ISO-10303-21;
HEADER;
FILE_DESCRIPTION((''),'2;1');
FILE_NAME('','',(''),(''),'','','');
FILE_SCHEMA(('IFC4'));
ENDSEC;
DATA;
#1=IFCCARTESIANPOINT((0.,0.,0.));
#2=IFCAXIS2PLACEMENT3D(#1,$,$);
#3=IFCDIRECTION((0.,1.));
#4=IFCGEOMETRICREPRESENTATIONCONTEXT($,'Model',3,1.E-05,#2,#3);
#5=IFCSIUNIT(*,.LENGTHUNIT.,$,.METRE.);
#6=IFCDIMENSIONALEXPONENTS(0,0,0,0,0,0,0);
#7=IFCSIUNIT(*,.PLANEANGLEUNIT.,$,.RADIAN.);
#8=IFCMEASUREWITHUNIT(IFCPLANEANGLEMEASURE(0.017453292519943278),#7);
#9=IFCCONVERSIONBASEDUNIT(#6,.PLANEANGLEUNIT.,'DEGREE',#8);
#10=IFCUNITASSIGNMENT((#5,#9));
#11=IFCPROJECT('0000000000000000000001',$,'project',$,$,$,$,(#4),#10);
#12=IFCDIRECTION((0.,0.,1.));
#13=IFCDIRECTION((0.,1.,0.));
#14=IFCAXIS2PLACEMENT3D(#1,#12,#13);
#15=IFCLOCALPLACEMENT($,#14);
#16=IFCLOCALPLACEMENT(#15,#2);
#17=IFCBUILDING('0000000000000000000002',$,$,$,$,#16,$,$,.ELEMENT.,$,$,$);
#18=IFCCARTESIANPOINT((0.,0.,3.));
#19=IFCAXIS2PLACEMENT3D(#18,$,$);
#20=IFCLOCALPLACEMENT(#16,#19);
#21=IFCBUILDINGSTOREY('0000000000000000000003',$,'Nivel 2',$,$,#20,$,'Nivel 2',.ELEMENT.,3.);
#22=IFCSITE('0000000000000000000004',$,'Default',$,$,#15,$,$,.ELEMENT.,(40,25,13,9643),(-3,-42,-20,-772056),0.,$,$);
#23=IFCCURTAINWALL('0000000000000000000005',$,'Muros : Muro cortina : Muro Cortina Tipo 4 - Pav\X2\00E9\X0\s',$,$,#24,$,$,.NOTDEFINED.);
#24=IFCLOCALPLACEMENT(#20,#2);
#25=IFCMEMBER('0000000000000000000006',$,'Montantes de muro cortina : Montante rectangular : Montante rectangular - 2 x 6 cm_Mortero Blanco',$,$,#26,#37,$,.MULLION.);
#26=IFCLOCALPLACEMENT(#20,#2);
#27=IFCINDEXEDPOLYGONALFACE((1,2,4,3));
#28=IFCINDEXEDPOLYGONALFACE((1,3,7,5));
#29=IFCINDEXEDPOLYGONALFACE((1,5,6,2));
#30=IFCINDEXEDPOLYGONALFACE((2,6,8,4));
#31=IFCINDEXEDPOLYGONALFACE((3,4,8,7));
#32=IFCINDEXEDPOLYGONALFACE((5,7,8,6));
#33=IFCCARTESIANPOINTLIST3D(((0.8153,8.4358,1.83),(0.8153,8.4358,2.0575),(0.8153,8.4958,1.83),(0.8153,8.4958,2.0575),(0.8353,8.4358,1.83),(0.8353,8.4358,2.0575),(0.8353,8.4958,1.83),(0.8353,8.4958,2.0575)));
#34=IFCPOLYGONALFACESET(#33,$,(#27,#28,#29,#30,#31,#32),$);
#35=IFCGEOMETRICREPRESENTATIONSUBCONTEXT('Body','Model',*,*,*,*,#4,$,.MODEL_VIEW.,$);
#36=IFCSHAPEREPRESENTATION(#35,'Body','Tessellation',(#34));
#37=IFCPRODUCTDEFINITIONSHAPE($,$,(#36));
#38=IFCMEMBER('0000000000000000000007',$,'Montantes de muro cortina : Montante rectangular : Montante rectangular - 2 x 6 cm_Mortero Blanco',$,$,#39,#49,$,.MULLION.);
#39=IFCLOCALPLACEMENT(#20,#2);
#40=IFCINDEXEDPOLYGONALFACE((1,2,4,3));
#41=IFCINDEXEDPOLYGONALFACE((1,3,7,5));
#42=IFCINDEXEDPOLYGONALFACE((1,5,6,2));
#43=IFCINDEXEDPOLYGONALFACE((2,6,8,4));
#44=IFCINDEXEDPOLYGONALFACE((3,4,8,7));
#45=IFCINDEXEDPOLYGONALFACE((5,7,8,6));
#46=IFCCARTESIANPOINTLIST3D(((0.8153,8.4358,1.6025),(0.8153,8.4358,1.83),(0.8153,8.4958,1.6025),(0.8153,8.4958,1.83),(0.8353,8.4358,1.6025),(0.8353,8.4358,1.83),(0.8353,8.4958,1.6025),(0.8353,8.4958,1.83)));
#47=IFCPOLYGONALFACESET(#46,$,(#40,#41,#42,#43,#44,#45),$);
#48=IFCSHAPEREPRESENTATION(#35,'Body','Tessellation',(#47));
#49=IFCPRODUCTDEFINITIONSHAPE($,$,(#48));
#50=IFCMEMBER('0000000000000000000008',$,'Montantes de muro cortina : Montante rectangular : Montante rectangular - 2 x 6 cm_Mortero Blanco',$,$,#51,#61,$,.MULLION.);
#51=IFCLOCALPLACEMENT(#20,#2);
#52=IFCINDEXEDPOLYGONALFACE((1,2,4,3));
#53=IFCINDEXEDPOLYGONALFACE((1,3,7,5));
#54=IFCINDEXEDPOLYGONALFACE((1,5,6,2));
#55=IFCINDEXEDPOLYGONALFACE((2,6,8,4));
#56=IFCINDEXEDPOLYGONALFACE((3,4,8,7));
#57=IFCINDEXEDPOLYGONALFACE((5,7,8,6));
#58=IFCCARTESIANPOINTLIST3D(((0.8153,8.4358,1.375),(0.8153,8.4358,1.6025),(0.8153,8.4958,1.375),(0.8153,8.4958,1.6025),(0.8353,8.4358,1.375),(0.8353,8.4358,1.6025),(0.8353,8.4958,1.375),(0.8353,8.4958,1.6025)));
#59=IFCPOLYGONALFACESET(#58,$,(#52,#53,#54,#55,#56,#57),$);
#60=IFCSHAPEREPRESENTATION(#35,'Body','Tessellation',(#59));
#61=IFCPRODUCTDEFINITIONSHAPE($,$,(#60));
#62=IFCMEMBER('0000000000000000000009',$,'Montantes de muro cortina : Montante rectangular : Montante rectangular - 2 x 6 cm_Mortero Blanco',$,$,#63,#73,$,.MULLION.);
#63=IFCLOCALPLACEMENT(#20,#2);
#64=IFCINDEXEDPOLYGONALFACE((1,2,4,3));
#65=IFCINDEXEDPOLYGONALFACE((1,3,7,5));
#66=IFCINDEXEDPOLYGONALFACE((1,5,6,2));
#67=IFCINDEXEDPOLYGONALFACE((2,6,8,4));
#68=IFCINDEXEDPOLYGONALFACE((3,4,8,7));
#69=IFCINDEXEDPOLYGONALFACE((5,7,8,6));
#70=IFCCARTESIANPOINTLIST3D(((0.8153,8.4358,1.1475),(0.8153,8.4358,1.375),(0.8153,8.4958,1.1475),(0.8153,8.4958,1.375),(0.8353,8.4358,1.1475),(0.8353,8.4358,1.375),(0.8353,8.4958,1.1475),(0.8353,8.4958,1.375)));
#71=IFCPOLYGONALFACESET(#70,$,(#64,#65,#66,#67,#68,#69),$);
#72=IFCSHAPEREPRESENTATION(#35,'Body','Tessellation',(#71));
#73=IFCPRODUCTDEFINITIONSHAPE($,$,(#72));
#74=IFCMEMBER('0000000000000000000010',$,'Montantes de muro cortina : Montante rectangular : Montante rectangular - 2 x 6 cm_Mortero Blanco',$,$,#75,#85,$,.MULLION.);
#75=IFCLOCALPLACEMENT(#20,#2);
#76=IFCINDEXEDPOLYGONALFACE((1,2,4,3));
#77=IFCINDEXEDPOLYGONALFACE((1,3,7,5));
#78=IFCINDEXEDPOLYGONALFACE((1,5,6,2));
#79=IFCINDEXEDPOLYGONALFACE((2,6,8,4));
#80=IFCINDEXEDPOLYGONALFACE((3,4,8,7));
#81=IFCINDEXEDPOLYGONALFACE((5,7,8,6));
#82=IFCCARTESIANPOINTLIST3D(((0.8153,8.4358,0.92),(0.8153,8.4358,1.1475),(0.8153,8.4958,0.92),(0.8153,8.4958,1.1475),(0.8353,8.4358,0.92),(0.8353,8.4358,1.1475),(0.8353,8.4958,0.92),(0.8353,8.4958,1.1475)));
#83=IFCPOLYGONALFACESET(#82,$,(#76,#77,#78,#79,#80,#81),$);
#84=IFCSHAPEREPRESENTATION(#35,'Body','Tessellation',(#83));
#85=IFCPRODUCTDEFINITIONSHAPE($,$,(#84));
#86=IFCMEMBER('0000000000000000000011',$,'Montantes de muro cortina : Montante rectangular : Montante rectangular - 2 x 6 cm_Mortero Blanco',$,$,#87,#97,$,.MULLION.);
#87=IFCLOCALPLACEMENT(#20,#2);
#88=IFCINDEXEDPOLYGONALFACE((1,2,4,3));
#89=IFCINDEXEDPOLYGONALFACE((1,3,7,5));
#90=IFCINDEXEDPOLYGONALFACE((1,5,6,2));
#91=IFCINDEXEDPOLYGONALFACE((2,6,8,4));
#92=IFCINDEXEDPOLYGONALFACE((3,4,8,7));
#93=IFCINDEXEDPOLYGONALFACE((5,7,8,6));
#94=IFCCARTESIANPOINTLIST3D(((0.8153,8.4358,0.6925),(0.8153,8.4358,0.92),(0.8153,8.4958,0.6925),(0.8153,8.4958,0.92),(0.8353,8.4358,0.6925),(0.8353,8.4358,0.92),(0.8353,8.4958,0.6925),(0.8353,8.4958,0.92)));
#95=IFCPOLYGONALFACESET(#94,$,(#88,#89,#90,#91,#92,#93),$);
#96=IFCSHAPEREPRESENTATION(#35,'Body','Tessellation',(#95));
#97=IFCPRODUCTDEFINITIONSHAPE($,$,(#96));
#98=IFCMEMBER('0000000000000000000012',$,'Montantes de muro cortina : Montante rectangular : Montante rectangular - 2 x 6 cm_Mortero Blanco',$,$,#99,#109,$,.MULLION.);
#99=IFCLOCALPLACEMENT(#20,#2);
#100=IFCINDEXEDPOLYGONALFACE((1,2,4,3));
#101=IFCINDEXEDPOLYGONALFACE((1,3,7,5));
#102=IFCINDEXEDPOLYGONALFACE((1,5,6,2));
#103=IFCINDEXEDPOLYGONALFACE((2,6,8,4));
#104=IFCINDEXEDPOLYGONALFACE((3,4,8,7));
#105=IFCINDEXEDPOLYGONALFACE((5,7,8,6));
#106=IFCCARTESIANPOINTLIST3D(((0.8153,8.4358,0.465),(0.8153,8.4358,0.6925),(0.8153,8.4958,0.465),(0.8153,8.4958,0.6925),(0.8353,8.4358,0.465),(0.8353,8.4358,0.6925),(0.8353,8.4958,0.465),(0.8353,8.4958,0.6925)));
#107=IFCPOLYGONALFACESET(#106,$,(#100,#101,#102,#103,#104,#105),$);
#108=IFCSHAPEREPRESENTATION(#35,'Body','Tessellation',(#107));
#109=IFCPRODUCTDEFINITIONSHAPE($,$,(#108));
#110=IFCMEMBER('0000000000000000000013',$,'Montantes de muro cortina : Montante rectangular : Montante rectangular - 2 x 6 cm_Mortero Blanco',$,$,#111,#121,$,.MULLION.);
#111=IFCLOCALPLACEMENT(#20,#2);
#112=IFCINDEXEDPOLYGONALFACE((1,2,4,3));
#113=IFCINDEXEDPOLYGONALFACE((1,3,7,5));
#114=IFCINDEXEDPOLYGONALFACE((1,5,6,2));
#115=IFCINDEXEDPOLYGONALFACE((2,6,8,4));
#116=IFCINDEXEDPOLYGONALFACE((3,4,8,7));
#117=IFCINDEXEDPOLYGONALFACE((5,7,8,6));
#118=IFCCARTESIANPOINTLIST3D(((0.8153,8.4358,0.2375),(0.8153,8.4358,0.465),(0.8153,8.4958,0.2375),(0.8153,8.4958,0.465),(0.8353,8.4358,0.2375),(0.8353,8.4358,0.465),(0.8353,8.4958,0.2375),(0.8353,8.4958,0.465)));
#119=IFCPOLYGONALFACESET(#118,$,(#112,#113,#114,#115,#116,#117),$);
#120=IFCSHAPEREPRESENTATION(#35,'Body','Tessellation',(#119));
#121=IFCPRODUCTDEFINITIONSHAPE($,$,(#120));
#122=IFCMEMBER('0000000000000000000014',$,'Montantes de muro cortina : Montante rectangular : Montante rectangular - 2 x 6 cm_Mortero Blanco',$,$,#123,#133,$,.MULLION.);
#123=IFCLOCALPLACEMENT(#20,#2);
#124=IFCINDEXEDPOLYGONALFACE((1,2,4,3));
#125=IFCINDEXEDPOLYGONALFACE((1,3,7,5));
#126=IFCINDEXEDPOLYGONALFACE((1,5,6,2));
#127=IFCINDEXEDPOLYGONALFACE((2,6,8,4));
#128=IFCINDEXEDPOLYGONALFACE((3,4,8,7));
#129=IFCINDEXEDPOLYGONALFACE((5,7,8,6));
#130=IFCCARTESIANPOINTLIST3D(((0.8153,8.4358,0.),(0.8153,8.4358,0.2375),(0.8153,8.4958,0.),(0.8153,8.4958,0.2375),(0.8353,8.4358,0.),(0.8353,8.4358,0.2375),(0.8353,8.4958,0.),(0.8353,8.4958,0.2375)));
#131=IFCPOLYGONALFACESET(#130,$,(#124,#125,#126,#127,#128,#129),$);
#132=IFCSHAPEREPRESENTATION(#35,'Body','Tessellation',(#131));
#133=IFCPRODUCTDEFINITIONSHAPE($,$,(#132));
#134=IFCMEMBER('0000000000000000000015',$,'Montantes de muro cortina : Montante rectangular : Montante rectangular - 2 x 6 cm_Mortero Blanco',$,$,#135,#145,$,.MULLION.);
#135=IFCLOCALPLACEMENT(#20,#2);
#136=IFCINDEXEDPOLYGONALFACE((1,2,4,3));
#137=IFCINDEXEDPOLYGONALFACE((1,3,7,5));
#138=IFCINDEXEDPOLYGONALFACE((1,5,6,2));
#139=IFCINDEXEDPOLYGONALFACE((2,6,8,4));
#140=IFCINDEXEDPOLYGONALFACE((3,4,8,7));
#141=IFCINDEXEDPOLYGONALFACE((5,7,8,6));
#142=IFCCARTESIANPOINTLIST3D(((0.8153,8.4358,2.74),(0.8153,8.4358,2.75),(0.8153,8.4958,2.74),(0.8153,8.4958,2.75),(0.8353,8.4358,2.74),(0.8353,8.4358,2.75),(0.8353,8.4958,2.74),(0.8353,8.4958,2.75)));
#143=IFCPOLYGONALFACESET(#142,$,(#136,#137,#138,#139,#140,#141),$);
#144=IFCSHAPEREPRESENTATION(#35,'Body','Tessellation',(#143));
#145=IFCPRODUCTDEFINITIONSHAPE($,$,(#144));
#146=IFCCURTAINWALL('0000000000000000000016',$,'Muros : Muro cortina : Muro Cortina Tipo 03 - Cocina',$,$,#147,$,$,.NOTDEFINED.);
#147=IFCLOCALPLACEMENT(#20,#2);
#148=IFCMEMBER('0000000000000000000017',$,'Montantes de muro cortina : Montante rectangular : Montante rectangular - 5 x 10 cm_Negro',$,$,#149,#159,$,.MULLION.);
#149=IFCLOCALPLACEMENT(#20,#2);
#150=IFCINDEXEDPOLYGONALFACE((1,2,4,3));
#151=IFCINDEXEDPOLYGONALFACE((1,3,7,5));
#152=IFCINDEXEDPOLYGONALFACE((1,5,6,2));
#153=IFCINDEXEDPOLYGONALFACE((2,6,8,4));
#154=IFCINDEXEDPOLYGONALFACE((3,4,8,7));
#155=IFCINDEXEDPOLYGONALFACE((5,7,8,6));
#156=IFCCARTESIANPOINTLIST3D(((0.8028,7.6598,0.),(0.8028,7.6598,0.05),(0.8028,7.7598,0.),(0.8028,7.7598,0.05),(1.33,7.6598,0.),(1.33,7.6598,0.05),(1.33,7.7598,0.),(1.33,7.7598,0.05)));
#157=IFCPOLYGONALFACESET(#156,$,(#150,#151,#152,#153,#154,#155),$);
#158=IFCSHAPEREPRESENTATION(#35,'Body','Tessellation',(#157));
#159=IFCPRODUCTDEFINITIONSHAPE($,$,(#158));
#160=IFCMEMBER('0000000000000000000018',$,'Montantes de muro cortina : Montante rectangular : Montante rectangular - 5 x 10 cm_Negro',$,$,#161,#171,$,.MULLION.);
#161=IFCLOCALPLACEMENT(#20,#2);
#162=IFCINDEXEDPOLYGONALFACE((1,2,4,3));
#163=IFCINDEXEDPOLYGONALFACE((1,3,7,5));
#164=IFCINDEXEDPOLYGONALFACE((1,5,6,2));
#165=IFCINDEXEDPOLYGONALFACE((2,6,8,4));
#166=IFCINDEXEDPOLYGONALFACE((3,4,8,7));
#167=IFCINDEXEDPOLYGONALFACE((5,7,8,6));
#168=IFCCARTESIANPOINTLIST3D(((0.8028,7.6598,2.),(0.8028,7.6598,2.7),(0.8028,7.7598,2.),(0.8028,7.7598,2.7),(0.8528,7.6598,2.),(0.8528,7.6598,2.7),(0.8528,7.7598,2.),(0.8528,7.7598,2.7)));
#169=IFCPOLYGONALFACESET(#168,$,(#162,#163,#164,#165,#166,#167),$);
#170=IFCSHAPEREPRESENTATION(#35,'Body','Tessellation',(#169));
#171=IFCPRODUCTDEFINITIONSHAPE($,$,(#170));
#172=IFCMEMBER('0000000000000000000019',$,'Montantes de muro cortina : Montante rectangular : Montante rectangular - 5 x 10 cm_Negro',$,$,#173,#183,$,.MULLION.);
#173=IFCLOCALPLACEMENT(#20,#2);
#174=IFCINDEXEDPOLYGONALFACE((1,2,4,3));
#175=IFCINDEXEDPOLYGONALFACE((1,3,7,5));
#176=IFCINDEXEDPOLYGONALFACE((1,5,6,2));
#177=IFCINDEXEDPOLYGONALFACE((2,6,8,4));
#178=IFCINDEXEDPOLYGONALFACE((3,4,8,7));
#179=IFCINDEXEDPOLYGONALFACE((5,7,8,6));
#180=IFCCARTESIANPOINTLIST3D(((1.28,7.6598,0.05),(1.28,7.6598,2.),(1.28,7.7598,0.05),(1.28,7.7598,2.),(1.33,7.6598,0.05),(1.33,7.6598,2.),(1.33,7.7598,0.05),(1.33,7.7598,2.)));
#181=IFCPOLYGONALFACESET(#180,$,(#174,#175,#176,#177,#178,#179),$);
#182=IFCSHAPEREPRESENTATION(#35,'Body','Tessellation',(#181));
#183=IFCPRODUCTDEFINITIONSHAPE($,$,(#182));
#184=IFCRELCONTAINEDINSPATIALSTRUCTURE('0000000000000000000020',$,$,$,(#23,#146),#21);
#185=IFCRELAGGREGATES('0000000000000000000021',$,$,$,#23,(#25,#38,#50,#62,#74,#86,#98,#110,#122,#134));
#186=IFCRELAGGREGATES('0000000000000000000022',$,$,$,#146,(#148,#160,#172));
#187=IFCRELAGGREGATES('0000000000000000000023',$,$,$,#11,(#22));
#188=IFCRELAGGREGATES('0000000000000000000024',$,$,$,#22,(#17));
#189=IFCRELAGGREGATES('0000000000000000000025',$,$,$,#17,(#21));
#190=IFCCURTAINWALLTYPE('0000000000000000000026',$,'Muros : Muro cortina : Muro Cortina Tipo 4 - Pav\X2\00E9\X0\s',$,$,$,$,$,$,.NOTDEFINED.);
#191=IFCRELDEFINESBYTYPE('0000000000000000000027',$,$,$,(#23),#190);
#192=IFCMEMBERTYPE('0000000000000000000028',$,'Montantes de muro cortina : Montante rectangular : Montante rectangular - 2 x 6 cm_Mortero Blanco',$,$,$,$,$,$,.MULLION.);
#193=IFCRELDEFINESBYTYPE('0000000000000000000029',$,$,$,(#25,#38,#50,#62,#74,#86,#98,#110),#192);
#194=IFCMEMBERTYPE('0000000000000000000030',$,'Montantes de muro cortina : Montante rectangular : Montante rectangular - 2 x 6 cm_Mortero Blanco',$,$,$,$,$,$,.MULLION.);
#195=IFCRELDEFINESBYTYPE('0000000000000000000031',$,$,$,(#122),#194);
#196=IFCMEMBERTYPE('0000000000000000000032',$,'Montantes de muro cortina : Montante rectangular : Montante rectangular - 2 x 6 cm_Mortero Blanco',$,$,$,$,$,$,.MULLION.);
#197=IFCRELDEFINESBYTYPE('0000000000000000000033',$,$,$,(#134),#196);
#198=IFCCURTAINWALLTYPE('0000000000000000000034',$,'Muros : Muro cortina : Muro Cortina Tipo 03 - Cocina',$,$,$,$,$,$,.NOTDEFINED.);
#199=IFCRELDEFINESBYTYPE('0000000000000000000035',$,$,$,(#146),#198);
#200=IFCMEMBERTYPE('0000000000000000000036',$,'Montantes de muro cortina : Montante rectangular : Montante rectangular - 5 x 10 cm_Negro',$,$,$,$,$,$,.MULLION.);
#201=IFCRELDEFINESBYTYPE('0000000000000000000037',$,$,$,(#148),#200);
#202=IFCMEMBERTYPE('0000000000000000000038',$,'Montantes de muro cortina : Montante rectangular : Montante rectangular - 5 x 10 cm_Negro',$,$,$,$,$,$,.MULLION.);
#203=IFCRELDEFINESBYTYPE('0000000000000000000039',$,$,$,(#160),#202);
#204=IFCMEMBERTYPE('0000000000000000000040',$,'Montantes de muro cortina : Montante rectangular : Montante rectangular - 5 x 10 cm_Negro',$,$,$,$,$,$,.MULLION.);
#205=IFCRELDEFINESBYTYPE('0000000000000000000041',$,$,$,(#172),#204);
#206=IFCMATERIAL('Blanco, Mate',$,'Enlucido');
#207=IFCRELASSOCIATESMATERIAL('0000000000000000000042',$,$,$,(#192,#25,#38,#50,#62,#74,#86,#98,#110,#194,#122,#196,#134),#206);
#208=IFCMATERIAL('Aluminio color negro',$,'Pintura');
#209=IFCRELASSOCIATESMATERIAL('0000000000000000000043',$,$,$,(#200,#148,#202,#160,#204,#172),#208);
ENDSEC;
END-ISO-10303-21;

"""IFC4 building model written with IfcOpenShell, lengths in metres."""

from ifc_helpers import new_model, entity, si_unit, converted_unit, direction, frame, origin, place, context, subcontext, project, spatial, indexed_curve, outline, extrude, source, transform, mapped, material, type_object, type_shapes, element, aggregate, save


model = new_model("IFC4")

# Units and contexts
model_context = context("Model", 3, precision=1e-05, world=origin(), true_north=direction((0.0, 1.0)))
body_context = subcontext(model_context, "Body", "Model", "MODEL_VIEW")
ifc_project = project(units=[si_unit("LENGTHUNIT", "METRE"), converted_unit("PLANEANGLEUNIT", "DEGREE", entity("IfcPlaneAngleMeasure", 0.017453292519943278), si_unit("PLANEANGLEUNIT", "RADIAN"), dimensions=[0, 0, 0, 0, 0, 0, 0])], contexts=[model_context])

# Site, building, storey
site_placement = place(None, frame((0.0, 0.0, 0.0), z_axis=(0.0, 0.0, 1.0), x_axis=(0.0, 1.0, 0.0)))
site = spatial("IfcSite", under=ifc_project, at=site_placement, Name="Default", CompositionType="ELEMENT", RefLatitude=(40, 25, 13, 9643), RefLongitude=(-3, -42, -20, -772056), RefElevation=0.0)
building_placement = place(site_placement, origin())
building = spatial("IfcBuilding", under=site, at=building_placement, CompositionType="ELEMENT")
storey_placement = place(building_placement, frame((0.0, 0.0, 3.0)))
storey = spatial("IfcBuildingStorey", under=building, at=storey_placement, Name="Nivel 2", LongName="Nivel 2", CompositionType="ELEMENT", Elevation=3.0)

# Curtain wall, members
curtain_wall_type_1 = type_object("IfcCurtainWallType", Name="Muros : Muro cortina : Muro Cortina Tipo 4 - Pavés", PredefinedType="NOTDEFINED")
curtain_wall_1_placement = place(storey_placement, frame((0.0, 0.0, -3.0)))
curtain_wall_1 = element("IfcCurtainWall", 1, at=curtain_wall_1_placement, inside=storey, type_object=curtain_wall_type_1, Name="Muros : Muro cortina : Muro Cortina Tipo 4 - Pavés", PredefinedType="NOTDEFINED")
ifc_material_1 = material(Name="Blanco, Mate", Category="Enlucido")
member_type_1 = type_object("IfcMemberType", Name="Montantes de muro cortina : Montante rectangular : Montante rectangular - 2 x 6 cm_Mortero Blanco", PredefinedType="MULLION", material=ifc_material_1)
shared_shape_1 = source(origin(), body_context, "Body", "SweptSolid", [
    extrude(outline(indexed_curve([(-0.01, -0.03), (0.01, -0.03), (0.01, 0.03), (-0.01, 0.03), (-0.01, -0.03)], self_intersect=False)), frame((-0.01, 0.0, -0.2275), z_axis=(0.0, 0.0, 1.0), x_axis=(-1.0, 0.0, 0.0)), (0.0, 0.0, 1.0), 0.2275),
])
type_shapes(member_type_1, [shared_shape_1])
member_1_placement = place(curtain_wall_1_placement, frame((0.8353, 8.4658, 5.0575)))
member_1 = element("IfcMember", 2, at=member_1_placement, type_object=member_type_1, material=ifc_material_1, Name="Montantes de muro cortina : Montante rectangular : Montante rectangular - 2 x 6 cm_Mortero Blanco", PredefinedType="MULLION", context=body_context, shape_type="MappedRepresentation", body=[
    mapped(shared_shape_1, transform((0.0, 0.0, 0.0), scale=1.0)),
])
member_2_placement = place(curtain_wall_1_placement, frame((0.8353, 8.4658, 4.83)))
member_2 = element("IfcMember", 3, at=member_2_placement, type_object=member_type_1, material=ifc_material_1, Name="Montantes de muro cortina : Montante rectangular : Montante rectangular - 2 x 6 cm_Mortero Blanco", PredefinedType="MULLION", context=body_context, shape_type="MappedRepresentation", body=[
    mapped(shared_shape_1, transform((0.0, 0.0, 0.0), scale=1.0)),
])
member_3_placement = place(curtain_wall_1_placement, frame((0.8353, 8.4658, 4.6025)))
member_3 = element("IfcMember", 4, at=member_3_placement, type_object=member_type_1, material=ifc_material_1, Name="Montantes de muro cortina : Montante rectangular : Montante rectangular - 2 x 6 cm_Mortero Blanco", PredefinedType="MULLION", context=body_context, shape_type="MappedRepresentation", body=[
    mapped(shared_shape_1, transform((0.0, 0.0, 0.0), scale=1.0)),
])
member_4_placement = place(curtain_wall_1_placement, frame((0.8353, 8.4658, 4.375)))
member_4 = element("IfcMember", 5, at=member_4_placement, type_object=member_type_1, material=ifc_material_1, Name="Montantes de muro cortina : Montante rectangular : Montante rectangular - 2 x 6 cm_Mortero Blanco", PredefinedType="MULLION", context=body_context, shape_type="MappedRepresentation", body=[
    mapped(shared_shape_1, transform((0.0, 0.0, 0.0), scale=1.0)),
])
member_5_placement = place(curtain_wall_1_placement, frame((0.8353, 8.4658, 4.1475)))
member_5 = element("IfcMember", 6, at=member_5_placement, type_object=member_type_1, material=ifc_material_1, Name="Montantes de muro cortina : Montante rectangular : Montante rectangular - 2 x 6 cm_Mortero Blanco", PredefinedType="MULLION", context=body_context, shape_type="MappedRepresentation", body=[
    mapped(shared_shape_1, transform((0.0, 0.0, 0.0), scale=1.0)),
])
member_6_placement = place(curtain_wall_1_placement, frame((0.8353, 8.4658, 3.92)))
member_6 = element("IfcMember", 7, at=member_6_placement, type_object=member_type_1, material=ifc_material_1, Name="Montantes de muro cortina : Montante rectangular : Montante rectangular - 2 x 6 cm_Mortero Blanco", PredefinedType="MULLION", context=body_context, shape_type="MappedRepresentation", body=[
    mapped(shared_shape_1, transform((0.0, 0.0, 0.0), scale=1.0)),
])
member_7_placement = place(curtain_wall_1_placement, frame((0.8353, 8.4658, 3.6925)))
member_7 = element("IfcMember", 8, at=member_7_placement, type_object=member_type_1, material=ifc_material_1, Name="Montantes de muro cortina : Montante rectangular : Montante rectangular - 2 x 6 cm_Mortero Blanco", PredefinedType="MULLION", context=body_context, shape_type="MappedRepresentation", body=[
    mapped(shared_shape_1, transform((0.0, 0.0, 0.0), scale=1.0)),
])
member_8_placement = place(curtain_wall_1_placement, frame((0.8353, 8.4658, 3.465)))
member_8 = element("IfcMember", 9, at=member_8_placement, type_object=member_type_1, material=ifc_material_1, Name="Montantes de muro cortina : Montante rectangular : Montante rectangular - 2 x 6 cm_Mortero Blanco", PredefinedType="MULLION", context=body_context, shape_type="MappedRepresentation", body=[
    mapped(shared_shape_1, transform((0.0, 0.0, 0.0), scale=1.0)),
])
member_type_2 = type_object("IfcMemberType", Name="Montantes de muro cortina : Montante rectangular : Montante rectangular - 2 x 6 cm_Mortero Blanco", PredefinedType="MULLION", material=ifc_material_1)
shared_shape_2 = source(origin(), body_context, "Body", "SweptSolid", [
    extrude(outline(indexed_curve([(-0.01, -0.03), (0.01, -0.03), (0.01, 0.03), (-0.01, 0.03), (-0.01, -0.03)], self_intersect=False)), frame((-0.01, 0.0, -0.2375), z_axis=(0.0, 0.0, 1.0), x_axis=(-1.0, 0.0, 0.0)), (0.0, 0.0, 1.0), 0.2375),
])
type_shapes(member_type_2, [shared_shape_2])
member_9_placement = place(curtain_wall_1_placement, frame((0.8353, 8.4658, 3.2375)))
member_9 = element("IfcMember", 10, at=member_9_placement, type_object=member_type_2, material=ifc_material_1, Name="Montantes de muro cortina : Montante rectangular : Montante rectangular - 2 x 6 cm_Mortero Blanco", PredefinedType="MULLION", context=body_context, shape_type="MappedRepresentation", body=[
    mapped(shared_shape_2, transform((0.0, 0.0, 0.0), scale=1.0)),
])
member_type_3 = type_object("IfcMemberType", Name="Montantes de muro cortina : Montante rectangular : Montante rectangular - 2 x 6 cm_Mortero Blanco", PredefinedType="MULLION", material=ifc_material_1)
shared_shape_3 = source(origin(), body_context, "Body", "SweptSolid", [
    extrude(outline(indexed_curve([(-0.01, -0.03), (0.01, -0.03), (0.01, 0.03), (-0.01, 0.03), (-0.01, -0.03)], self_intersect=False)), frame((-0.01, 0.0, -0.01), z_axis=(0.0, 0.0, 1.0), x_axis=(-1.0, 0.0, 0.0)), (0.0, 0.0, 1.0), 0.01),
])
type_shapes(member_type_3, [shared_shape_3])
member_10_placement = place(curtain_wall_1_placement, frame((0.8353, 8.4658, 5.75)))
member_10 = element("IfcMember", 11, at=member_10_placement, type_object=member_type_3, material=ifc_material_1, Name="Montantes de muro cortina : Montante rectangular : Montante rectangular - 2 x 6 cm_Mortero Blanco", PredefinedType="MULLION", context=body_context, shape_type="MappedRepresentation", body=[
    mapped(shared_shape_3, transform((0.0, 0.0, 0.0), scale=1.0)),
])
aggregate(curtain_wall_1, [member_1, member_2, member_3, member_4, member_5, member_6, member_7, member_8, member_9, member_10])

# Curtain wall, members
curtain_wall_type_2 = type_object("IfcCurtainWallType", Name="Muros : Muro cortina : Muro Cortina Tipo 03 - Cocina", PredefinedType="NOTDEFINED")
curtain_wall_2_placement = place(storey_placement, frame((0.0, 0.0, -3.0)))
curtain_wall_2 = element("IfcCurtainWall", 12, at=curtain_wall_2_placement, inside=storey, type_object=curtain_wall_type_2, Name="Muros : Muro cortina : Muro Cortina Tipo 03 - Cocina", PredefinedType="NOTDEFINED")
ifc_material_2 = material(Name="Aluminio color negro", Category="Pintura")
member_type_4 = type_object("IfcMemberType", Name="Montantes de muro cortina : Montante rectangular : Montante rectangular - 5 x 10 cm_Negro", PredefinedType="MULLION", material=ifc_material_2)
shared_shape_4 = source(origin(), body_context, "Body", "SweptSolid", [
    extrude(outline(indexed_curve([(-0.05, -0.025), (0.05, -0.025), (0.05, 0.025), (-0.05, 0.025), (-0.05, -0.025)], self_intersect=False)), frame((-0.025, 0.0, -0.5272), z_axis=(0.0, 0.0, 1.0), x_axis=(0.0, -1.0, 0.0)), (0.0, 0.0, 1.0), 0.5272),
])
type_shapes(member_type_4, [shared_shape_4])
member_11_placement = place(curtain_wall_2_placement, frame((0.8028, 7.7098, 3.0), z_axis=(-1.0, 0.0, 0.0), x_axis=(0.0, 0.0, -1.0)))
member_11 = element("IfcMember", 13, at=member_11_placement, type_object=member_type_4, material=ifc_material_2, Name="Montantes de muro cortina : Montante rectangular : Montante rectangular - 5 x 10 cm_Negro", PredefinedType="MULLION", context=body_context, shape_type="MappedRepresentation", body=[
    mapped(shared_shape_4, transform((0.0, 0.0, 0.0), scale=1.0)),
])
member_type_5 = type_object("IfcMemberType", Name="Montantes de muro cortina : Montante rectangular : Montante rectangular - 5 x 10 cm_Negro", PredefinedType="MULLION", material=ifc_material_2)
shared_shape_5 = source(origin(), body_context, "Body", "SweptSolid", [
    extrude(outline(indexed_curve([(-0.05, -0.025), (0.05, -0.025), (0.05, 0.025), (-0.05, 0.025), (-0.05, -0.025)], self_intersect=False)), frame((-0.025, 0.0, -0.7), z_axis=(0.0, 0.0, 1.0), x_axis=(0.0, -1.0, 0.0)), (0.0, 0.0, 1.0), 0.7),
])
type_shapes(member_type_5, [shared_shape_5])
member_12_placement = place(curtain_wall_2_placement, frame((0.8028, 7.7098, 5.7), z_axis=(0.0, 0.0, 1.0), x_axis=(-1.0, 0.0, 0.0)))
member_12 = element("IfcMember", 14, at=member_12_placement, type_object=member_type_5, material=ifc_material_2, Name="Montantes de muro cortina : Montante rectangular : Montante rectangular - 5 x 10 cm_Negro", PredefinedType="MULLION", context=body_context, shape_type="MappedRepresentation", body=[
    mapped(shared_shape_5, transform((0.0, 0.0, 0.0), scale=1.0)),
])
member_type_6 = type_object("IfcMemberType", Name="Montantes de muro cortina : Montante rectangular : Montante rectangular - 5 x 10 cm_Negro", PredefinedType="MULLION", material=ifc_material_2)
shared_shape_6 = source(origin(), body_context, "Body", "SweptSolid", [
    extrude(outline(indexed_curve([(-0.025, -0.05), (0.025, -0.05), (0.025, 0.05), (-0.025, 0.05), (-0.025, -0.05)], self_intersect=False)), frame((0.0, 0.0, -1.95), z_axis=(0.0, 0.0, 1.0), x_axis=(-1.0, 0.0, 0.0)), (0.0, 0.0, 1.0), 1.95),
])
type_shapes(member_type_6, [shared_shape_6])
member_13_placement = place(curtain_wall_2_placement, frame((1.305, 7.7098, 3.05), z_axis=(0.0, 0.0, -1.0), x_axis=(1.0, 0.0, 0.0)))
member_13 = element("IfcMember", 15, at=member_13_placement, type_object=member_type_6, material=ifc_material_2, Name="Montantes de muro cortina : Montante rectangular : Montante rectangular - 5 x 10 cm_Negro", PredefinedType="MULLION", context=body_context, shape_type="MappedRepresentation", body=[
    mapped(shared_shape_6, transform((0.0, 0.0, 0.0), scale=1.0)),
])

aggregate(curtain_wall_2, [member_11, member_12, member_13])

save(model, "model.ifc")
